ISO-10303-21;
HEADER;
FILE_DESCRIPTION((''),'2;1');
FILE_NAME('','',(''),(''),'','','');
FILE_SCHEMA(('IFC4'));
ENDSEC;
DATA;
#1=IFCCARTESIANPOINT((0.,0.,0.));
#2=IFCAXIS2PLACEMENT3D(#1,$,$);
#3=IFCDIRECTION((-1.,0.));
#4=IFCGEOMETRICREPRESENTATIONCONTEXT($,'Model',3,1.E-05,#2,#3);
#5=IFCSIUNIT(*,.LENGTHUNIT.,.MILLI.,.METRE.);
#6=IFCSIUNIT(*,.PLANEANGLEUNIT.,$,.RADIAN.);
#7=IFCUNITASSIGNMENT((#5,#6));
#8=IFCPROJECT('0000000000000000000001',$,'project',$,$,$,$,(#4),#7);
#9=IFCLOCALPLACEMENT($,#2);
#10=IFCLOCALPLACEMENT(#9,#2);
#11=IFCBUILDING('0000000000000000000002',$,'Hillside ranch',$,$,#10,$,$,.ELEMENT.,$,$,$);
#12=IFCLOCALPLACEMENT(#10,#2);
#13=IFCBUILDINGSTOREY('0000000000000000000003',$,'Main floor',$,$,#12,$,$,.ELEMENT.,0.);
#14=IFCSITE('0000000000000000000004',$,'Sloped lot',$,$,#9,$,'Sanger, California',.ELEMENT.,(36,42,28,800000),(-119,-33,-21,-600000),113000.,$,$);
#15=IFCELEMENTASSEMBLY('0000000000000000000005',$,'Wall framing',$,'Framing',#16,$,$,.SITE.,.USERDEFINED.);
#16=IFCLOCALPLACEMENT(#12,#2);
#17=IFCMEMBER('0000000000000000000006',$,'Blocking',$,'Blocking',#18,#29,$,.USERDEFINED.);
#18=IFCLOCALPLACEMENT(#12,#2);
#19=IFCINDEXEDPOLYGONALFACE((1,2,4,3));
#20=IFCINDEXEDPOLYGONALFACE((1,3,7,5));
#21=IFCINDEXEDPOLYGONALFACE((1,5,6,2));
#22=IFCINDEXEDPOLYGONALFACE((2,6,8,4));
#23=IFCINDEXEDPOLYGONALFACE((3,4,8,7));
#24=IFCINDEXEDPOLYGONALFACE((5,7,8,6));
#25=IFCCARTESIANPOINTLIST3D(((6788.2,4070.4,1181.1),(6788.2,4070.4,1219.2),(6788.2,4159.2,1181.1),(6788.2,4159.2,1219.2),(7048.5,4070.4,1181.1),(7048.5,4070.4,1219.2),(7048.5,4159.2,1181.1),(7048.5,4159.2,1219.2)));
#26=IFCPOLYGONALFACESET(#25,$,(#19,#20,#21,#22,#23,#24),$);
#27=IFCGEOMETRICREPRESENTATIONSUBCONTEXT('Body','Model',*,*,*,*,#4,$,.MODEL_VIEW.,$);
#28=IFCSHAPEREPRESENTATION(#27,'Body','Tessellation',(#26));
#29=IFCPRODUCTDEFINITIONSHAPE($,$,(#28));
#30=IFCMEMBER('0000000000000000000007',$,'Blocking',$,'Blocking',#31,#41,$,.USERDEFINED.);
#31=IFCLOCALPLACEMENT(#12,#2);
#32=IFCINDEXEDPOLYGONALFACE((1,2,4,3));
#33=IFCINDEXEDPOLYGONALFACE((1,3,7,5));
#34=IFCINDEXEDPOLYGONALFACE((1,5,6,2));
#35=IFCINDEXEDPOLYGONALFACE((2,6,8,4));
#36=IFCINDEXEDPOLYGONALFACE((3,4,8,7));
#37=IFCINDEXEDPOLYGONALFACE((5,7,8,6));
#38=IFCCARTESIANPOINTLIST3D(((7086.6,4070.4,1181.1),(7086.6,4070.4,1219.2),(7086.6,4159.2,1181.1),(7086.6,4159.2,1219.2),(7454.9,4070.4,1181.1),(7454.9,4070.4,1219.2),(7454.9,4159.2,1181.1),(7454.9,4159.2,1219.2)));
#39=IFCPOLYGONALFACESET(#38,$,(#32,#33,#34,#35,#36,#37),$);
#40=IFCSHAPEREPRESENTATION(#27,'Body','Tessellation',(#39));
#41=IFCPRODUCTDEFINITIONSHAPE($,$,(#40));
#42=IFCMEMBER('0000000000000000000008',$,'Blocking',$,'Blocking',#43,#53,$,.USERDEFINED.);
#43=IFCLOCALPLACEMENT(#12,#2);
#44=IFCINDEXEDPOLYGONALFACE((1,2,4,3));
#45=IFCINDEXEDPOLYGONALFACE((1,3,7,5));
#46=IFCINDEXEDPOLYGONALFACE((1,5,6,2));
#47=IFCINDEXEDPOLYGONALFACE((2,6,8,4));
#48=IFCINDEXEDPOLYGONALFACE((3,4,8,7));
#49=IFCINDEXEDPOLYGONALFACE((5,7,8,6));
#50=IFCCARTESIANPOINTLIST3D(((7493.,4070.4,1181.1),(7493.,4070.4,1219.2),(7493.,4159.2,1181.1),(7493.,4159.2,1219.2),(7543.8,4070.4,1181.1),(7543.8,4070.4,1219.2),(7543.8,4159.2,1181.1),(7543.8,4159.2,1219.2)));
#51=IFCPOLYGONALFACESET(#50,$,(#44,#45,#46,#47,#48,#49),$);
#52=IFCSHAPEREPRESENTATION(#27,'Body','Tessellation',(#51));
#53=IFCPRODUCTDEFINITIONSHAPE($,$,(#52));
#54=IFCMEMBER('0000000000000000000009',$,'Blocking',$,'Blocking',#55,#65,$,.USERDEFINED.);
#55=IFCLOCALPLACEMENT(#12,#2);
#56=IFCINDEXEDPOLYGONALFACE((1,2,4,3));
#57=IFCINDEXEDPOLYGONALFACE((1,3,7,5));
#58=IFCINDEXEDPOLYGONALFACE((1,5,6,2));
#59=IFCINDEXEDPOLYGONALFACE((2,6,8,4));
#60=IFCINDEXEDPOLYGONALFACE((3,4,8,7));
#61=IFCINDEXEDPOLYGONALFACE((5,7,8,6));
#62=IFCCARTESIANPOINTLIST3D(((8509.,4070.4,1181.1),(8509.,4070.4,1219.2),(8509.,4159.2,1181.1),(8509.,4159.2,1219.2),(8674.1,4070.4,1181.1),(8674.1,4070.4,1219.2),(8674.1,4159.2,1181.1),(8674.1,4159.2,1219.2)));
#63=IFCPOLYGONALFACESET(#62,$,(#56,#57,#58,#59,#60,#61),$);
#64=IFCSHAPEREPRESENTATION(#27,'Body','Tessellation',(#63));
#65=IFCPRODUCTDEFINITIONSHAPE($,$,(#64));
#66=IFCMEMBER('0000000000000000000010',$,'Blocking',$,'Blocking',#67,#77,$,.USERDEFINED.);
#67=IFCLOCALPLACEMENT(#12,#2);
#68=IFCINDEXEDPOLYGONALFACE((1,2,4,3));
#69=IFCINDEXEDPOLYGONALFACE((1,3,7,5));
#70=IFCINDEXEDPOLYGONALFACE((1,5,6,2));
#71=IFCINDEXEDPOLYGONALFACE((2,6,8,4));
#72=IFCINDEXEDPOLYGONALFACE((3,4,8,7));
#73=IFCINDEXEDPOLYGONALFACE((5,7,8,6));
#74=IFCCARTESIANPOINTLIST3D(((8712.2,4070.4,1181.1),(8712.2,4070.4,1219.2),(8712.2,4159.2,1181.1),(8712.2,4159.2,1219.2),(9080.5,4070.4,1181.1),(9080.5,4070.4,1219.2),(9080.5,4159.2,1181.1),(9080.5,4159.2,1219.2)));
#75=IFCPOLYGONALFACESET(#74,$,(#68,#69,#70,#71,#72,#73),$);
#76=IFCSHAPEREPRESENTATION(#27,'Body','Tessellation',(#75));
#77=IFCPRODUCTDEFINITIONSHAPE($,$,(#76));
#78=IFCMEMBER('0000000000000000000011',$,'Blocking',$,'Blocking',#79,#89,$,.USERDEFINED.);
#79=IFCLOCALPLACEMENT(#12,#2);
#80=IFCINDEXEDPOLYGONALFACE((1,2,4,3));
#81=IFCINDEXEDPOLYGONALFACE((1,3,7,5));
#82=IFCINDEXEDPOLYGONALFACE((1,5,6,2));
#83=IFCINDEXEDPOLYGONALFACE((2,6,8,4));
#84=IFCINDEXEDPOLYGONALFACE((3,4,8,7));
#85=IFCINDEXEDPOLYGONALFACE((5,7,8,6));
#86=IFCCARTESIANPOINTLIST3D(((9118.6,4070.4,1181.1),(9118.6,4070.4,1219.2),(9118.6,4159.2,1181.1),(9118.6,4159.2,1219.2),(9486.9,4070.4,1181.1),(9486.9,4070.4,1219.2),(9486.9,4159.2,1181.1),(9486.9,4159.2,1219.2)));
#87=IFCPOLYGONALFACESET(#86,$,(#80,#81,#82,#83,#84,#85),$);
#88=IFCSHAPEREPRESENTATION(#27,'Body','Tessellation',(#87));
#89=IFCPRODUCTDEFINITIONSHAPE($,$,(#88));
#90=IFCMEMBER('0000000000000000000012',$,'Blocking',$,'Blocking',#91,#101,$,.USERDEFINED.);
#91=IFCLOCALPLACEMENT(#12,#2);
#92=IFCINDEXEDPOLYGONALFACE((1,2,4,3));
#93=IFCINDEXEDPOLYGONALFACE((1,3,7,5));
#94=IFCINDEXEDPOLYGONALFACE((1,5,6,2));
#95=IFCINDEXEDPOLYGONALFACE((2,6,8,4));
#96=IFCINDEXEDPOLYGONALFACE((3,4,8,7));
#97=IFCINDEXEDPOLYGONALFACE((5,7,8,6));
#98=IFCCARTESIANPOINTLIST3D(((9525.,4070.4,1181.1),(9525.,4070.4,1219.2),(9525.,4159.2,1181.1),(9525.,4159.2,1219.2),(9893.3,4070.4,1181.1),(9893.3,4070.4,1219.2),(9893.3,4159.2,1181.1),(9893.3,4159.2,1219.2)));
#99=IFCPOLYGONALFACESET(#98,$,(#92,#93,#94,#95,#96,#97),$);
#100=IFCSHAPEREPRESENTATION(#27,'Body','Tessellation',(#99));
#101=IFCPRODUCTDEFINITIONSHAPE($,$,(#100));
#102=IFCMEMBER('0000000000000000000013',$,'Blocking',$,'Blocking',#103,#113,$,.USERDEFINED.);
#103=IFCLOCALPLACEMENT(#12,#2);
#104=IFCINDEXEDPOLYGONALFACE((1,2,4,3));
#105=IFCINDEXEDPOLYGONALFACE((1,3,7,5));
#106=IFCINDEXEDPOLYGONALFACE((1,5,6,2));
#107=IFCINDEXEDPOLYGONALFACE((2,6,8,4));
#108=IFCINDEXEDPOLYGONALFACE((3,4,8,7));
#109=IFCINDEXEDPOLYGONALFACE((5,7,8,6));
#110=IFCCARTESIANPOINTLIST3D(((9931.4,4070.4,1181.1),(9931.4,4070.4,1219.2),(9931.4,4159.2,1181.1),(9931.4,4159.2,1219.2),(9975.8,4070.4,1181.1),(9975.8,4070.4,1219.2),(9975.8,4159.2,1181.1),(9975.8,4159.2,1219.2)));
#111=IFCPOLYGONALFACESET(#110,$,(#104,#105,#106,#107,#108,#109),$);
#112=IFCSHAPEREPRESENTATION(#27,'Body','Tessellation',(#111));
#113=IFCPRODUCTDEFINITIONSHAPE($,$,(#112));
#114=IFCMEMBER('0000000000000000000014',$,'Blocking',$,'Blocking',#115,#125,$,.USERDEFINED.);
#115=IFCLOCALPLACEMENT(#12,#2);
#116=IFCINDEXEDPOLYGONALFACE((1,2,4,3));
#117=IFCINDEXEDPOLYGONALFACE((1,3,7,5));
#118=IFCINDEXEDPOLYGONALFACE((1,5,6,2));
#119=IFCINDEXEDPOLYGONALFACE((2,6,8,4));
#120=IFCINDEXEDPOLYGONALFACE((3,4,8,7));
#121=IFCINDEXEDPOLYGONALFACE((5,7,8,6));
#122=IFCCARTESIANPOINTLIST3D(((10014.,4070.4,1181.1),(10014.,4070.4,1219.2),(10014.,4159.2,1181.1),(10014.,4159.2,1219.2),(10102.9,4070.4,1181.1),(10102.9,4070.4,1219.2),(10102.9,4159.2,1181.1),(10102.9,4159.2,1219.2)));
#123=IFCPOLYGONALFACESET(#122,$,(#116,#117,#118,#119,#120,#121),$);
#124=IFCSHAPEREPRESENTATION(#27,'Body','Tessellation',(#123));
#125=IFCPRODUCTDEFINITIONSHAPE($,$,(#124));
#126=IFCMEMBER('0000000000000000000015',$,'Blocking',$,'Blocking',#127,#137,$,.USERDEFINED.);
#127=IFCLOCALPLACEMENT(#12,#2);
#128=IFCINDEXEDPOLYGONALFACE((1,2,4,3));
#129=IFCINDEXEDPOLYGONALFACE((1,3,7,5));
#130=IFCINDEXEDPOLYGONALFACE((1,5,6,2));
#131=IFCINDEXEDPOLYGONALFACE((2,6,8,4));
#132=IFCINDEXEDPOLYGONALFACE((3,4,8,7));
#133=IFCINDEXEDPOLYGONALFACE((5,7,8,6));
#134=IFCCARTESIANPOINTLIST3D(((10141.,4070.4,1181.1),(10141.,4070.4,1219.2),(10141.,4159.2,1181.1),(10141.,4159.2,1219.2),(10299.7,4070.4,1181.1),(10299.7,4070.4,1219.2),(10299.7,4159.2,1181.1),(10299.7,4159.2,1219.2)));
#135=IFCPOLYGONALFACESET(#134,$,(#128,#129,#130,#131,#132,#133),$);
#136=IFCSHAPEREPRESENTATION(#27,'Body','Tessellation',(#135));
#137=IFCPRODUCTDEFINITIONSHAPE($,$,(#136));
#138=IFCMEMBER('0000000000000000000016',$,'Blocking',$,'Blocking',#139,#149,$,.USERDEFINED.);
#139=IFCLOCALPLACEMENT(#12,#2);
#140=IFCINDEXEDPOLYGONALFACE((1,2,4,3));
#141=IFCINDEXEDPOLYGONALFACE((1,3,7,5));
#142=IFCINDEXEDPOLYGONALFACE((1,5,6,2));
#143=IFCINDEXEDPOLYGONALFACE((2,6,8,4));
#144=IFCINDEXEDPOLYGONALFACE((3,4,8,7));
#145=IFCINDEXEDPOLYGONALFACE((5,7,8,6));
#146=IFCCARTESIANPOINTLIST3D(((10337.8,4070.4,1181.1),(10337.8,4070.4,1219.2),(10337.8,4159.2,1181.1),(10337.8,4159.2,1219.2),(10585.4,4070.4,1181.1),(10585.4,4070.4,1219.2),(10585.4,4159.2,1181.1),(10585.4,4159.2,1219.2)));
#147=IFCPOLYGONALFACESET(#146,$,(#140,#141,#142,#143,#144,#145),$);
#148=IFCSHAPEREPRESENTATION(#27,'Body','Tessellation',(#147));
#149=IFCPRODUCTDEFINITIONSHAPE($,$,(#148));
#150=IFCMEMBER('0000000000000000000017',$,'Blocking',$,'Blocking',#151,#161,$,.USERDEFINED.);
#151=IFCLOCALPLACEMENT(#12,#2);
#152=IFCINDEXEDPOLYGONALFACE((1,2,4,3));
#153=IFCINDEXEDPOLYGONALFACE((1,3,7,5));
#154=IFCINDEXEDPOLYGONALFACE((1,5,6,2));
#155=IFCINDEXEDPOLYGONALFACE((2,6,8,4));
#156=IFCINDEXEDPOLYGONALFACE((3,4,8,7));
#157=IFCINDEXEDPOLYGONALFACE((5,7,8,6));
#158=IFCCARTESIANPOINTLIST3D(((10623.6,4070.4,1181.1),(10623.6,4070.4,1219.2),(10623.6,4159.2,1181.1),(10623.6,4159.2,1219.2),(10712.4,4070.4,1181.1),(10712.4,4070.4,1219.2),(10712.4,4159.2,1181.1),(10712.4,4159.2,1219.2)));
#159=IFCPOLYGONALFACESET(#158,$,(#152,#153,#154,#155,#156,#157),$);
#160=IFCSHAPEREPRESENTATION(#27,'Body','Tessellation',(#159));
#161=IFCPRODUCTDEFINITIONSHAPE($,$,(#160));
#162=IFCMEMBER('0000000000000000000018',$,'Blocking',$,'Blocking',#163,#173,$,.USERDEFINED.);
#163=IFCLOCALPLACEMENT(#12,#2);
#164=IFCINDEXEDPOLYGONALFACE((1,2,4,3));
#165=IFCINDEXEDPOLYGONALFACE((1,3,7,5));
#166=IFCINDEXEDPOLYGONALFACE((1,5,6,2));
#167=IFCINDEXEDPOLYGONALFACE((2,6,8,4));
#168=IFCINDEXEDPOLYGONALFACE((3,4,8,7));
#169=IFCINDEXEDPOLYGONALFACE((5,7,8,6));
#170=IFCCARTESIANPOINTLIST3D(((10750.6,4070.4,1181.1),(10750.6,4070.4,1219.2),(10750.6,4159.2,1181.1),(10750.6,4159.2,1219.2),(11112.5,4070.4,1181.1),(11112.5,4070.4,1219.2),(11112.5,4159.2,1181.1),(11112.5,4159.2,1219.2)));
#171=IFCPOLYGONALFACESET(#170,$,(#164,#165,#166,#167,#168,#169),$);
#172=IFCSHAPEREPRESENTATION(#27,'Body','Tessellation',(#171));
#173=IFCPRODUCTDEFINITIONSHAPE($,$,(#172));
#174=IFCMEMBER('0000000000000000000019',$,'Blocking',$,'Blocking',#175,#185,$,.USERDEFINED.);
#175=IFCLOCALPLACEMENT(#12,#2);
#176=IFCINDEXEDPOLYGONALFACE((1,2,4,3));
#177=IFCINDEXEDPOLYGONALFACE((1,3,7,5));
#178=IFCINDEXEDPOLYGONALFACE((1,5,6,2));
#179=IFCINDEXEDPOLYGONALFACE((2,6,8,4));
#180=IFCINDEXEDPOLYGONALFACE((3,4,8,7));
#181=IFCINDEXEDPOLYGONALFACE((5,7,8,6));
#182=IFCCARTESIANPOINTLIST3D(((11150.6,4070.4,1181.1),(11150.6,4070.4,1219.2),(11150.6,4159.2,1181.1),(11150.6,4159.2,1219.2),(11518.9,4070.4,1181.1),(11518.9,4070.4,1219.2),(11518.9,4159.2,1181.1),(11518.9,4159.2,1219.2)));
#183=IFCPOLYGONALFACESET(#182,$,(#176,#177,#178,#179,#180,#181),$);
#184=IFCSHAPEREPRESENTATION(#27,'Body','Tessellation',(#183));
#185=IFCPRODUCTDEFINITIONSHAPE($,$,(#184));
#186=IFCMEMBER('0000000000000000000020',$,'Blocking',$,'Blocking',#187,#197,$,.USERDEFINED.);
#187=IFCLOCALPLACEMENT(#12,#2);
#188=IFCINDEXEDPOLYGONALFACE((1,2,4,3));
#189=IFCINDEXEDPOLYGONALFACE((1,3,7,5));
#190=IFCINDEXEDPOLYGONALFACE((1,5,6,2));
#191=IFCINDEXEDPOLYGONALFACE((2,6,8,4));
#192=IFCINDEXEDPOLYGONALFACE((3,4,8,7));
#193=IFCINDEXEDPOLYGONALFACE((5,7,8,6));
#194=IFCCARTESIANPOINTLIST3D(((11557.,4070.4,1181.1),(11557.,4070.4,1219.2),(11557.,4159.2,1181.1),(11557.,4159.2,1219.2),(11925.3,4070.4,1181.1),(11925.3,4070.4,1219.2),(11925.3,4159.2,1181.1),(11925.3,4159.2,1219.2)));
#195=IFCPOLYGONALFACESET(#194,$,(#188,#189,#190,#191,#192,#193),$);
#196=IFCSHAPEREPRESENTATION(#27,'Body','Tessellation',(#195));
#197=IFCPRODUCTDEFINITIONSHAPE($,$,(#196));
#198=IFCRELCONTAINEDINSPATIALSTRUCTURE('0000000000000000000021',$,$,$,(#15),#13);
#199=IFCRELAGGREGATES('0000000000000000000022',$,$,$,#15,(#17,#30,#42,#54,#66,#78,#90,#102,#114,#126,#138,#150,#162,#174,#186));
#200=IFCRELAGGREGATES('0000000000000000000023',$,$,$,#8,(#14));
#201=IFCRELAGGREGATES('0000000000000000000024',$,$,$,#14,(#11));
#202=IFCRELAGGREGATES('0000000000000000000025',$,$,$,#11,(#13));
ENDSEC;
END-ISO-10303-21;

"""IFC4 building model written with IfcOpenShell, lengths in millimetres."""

from ifc_helpers import new_model, si_unit, direction, frame, origin, origin_with_axes, place, context, subcontext, project, spatial, polyline, outline, extrude, element, aggregate, save


model = new_model("IFC4")

# Units and contexts
model_context = context("Model", 3, precision=1e-05, world=origin(), true_north=direction((-1.0, 0.0)))
body_context = subcontext(model_context, "Body", "Model", "MODEL_VIEW")
ifc_project = project(units=[si_unit("LENGTHUNIT", "METRE", prefix="MILLI"), si_unit("PLANEANGLEUNIT", "RADIAN")], contexts=[model_context])

# Site, building, storey
site_placement = place(None, origin())
site = spatial("IfcSite", under=ifc_project, at=site_placement, Name="Sloped lot", LongName="Sanger, California", CompositionType="ELEMENT", RefLatitude=(36, 42, 28, 800000), RefLongitude=(-119, -33, -21, -600000), RefElevation=113000.0)
building_placement = place(site_placement, origin())
building = spatial("IfcBuilding", under=site, at=building_placement, Name="Hillside ranch", CompositionType="ELEMENT")
storey_placement = place(building_placement, origin())
storey = spatial("IfcBuildingStorey", under=building, at=storey_placement, Name="Main floor", CompositionType="ELEMENT", Elevation=0.0)

# Element assembly, members
assembly_1_placement = place(storey_placement, origin_with_axes())
assembly_1 = element("IfcElementAssembly", 1, at=assembly_1_placement, inside=storey, Name="Wall framing", ObjectType="Framing", AssemblyPlace="SITE", PredefinedType="USERDEFINED")
member_1_placement = place(storey_placement, origin_with_axes())
member_1 = element("IfcMember", 2, at=member_1_placement, Name="Blocking", ObjectType="Blocking", PredefinedType="USERDEFINED", context=body_context, shape_type="SweptSolid", body=[
    extrude(outline(polyline([(0.0, 0.0), (260.4, 0.0), (260.4, 88.9), (0.0, 88.9), (0.0, 0.0)])), frame((6788.1, 4070.3, 1181.1), z_axis=(0.0, 0.0, 1.0), x_axis=(1.0, 0.0, 0.0)), (0.0, 0.0, 1.0), 38.1),
])
member_2_placement = place(storey_placement, origin_with_axes())
member_2 = element("IfcMember", 3, at=member_2_placement, Name="Blocking", ObjectType="Blocking", PredefinedType="USERDEFINED", context=body_context, shape_type="SweptSolid", body=[
    extrude(outline(polyline([(0.0, 0.0), (368.3, 0.0), (368.3, 88.9), (0.0, 88.9), (0.0, 0.0)])), frame((7086.6, 4070.3, 1181.1), z_axis=(0.0, 0.0, 1.0), x_axis=(1.0, 0.0, 0.0)), (0.0, 0.0, 1.0), 38.1),
])
member_3_placement = place(storey_placement, origin_with_axes())
member_3 = element("IfcMember", 4, at=member_3_placement, Name="Blocking", ObjectType="Blocking", PredefinedType="USERDEFINED", context=body_context, shape_type="SweptSolid", body=[
    extrude(outline(polyline([(0.0, 0.0), (50.8, 0.0), (50.8, 88.9), (0.0, 88.9), (0.0, 0.0)])), frame((7493.0, 4070.3, 1181.1), z_axis=(0.0, 0.0, 1.0), x_axis=(1.0, 0.0, 0.0)), (0.0, 0.0, 1.0), 38.1),
])
member_4_placement = place(storey_placement, origin_with_axes())
member_4 = element("IfcMember", 5, at=member_4_placement, Name="Blocking", ObjectType="Blocking", PredefinedType="USERDEFINED", context=body_context, shape_type="SweptSolid", body=[
    extrude(outline(polyline([(0.0, 0.0), (165.1, 0.0), (165.1, 88.9), (0.0, 88.9), (0.0, 0.0)])), frame((8509.0, 4070.3, 1181.1), z_axis=(0.0, 0.0, 1.0), x_axis=(1.0, 0.0, 0.0)), (0.0, 0.0, 1.0), 38.1),
])
member_5_placement = place(storey_placement, origin_with_axes())
member_5 = element("IfcMember", 6, at=member_5_placement, Name="Blocking", ObjectType="Blocking", PredefinedType="USERDEFINED", context=body_context, shape_type="SweptSolid", body=[
    extrude(outline(polyline([(0.0, 0.0), (368.3, 0.0), (368.3, 88.9), (0.0, 88.9), (0.0, 0.0)])), frame((8712.2, 4070.3, 1181.1), z_axis=(0.0, 0.0, 1.0), x_axis=(1.0, 0.0, 0.0)), (0.0, 0.0, 1.0), 38.1),
])
member_6_placement = place(storey_placement, origin_with_axes())
member_6 = element("IfcMember", 7, at=member_6_placement, Name="Blocking", ObjectType="Blocking", PredefinedType="USERDEFINED", context=body_context, shape_type="SweptSolid", body=[
    extrude(outline(polyline([(0.0, 0.0), (368.3, 0.0), (368.3, 88.9), (0.0, 88.9), (0.0, 0.0)])), frame((9118.6, 4070.3, 1181.1), z_axis=(0.0, 0.0, 1.0), x_axis=(1.0, 0.0, 0.0)), (0.0, 0.0, 1.0), 38.1),
])
member_7_placement = place(storey_placement, origin_with_axes())
member_7 = element("IfcMember", 8, at=member_7_placement, Name="Blocking", ObjectType="Blocking", PredefinedType="USERDEFINED", context=body_context, shape_type="SweptSolid", body=[
    extrude(outline(polyline([(0.0, 0.0), (368.3, 0.0), (368.3, 88.9), (0.0, 88.9), (0.0, 0.0)])), frame((9525.0, 4070.3, 1181.1), z_axis=(0.0, 0.0, 1.0), x_axis=(1.0, 0.0, 0.0)), (0.0, 0.0, 1.0), 38.1),
])
member_8_placement = place(storey_placement, origin_with_axes())
member_8 = element("IfcMember", 9, at=member_8_placement, Name="Blocking", ObjectType="Blocking", PredefinedType="USERDEFINED", context=body_context, shape_type="SweptSolid", body=[
    extrude(outline(polyline([(0.0, 0.0), (44.5, 0.0), (44.5, 88.9), (0.0, 88.9), (0.0, 0.0)])), frame((9931.4, 4070.3, 1181.1), z_axis=(0.0, 0.0, 1.0), x_axis=(1.0, 0.0, 0.0)), (0.0, 0.0, 1.0), 38.1),
])
member_9_placement = place(storey_placement, origin_with_axes())
member_9 = element("IfcMember", 10, at=member_9_placement, Name="Blocking", ObjectType="Blocking", PredefinedType="USERDEFINED", context=body_context, shape_type="SweptSolid", body=[
    extrude(outline(polyline([(0.0, 0.0), (88.9, 0.0), (88.9, 88.9), (0.0, 88.9), (0.0, 0.0)])), frame((10014.0, 4070.3, 1181.1), z_axis=(0.0, 0.0, 1.0), x_axis=(1.0, 0.0, 0.0)), (0.0, 0.0, 1.0), 38.1),
])
member_10_placement = place(storey_placement, origin_with_axes())
member_10 = element("IfcMember", 11, at=member_10_placement, Name="Blocking", ObjectType="Blocking", PredefinedType="USERDEFINED", context=body_context, shape_type="SweptSolid", body=[
    extrude(outline(polyline([(0.0, 0.0), (158.8, 0.0), (158.8, 88.9), (0.0, 88.9), (0.0, 0.0)])), frame((10141.0, 4070.3, 1181.1), z_axis=(0.0, 0.0, 1.0), x_axis=(1.0, 0.0, 0.0)), (0.0, 0.0, 1.0), 38.1),
])
member_11_placement = place(storey_placement, origin_with_axes())
member_11 = element("IfcMember", 12, at=member_11_placement, Name="Blocking", ObjectType="Blocking", PredefinedType="USERDEFINED", context=body_context, shape_type="SweptSolid", body=[
    extrude(outline(polyline([(0.0, 0.0), (247.7, 0.0), (247.7, 88.9), (0.0, 88.9), (0.0, 0.0)])), frame((10337.8, 4070.3, 1181.1), z_axis=(0.0, 0.0, 1.0), x_axis=(1.0, 0.0, 0.0)), (0.0, 0.0, 1.0), 38.1),
])
member_12_placement = place(storey_placement, origin_with_axes())
member_12 = element("IfcMember", 13, at=member_12_placement, Name="Blocking", ObjectType="Blocking", PredefinedType="USERDEFINED", context=body_context, shape_type="SweptSolid", body=[
    extrude(outline(polyline([(0.0, 0.0), (88.9, 0.0), (88.9, 88.9), (0.0, 88.9), (0.0, 0.0)])), frame((10623.5, 4070.3, 1181.1), z_axis=(0.0, 0.0, 1.0), x_axis=(1.0, 0.0, 0.0)), (0.0, 0.0, 1.0), 38.1),
])
member_13_placement = place(storey_placement, origin_with_axes())
member_13 = element("IfcMember", 14, at=member_13_placement, Name="Blocking", ObjectType="Blocking", PredefinedType="USERDEFINED", context=body_context, shape_type="SweptSolid", body=[
    extrude(outline(polyline([(0.0, 0.0), (361.9, 0.0), (361.9, 88.9), (0.0, 88.9), (0.0, 0.0)])), frame((10750.5, 4070.3, 1181.1), z_axis=(0.0, 0.0, 1.0), x_axis=(1.0, 0.0, 0.0)), (0.0, 0.0, 1.0), 38.1),
])
member_14_placement = place(storey_placement, origin_with_axes())
member_14 = element("IfcMember", 15, at=member_14_placement, Name="Blocking", ObjectType="Blocking", PredefinedType="USERDEFINED", context=body_context, shape_type="SweptSolid", body=[
    extrude(outline(polyline([(0.0, 0.0), (368.3, 0.0), (368.3, 88.9), (0.0, 88.9), (0.0, 0.0)])), frame((11150.6, 4070.3, 1181.1), z_axis=(0.0, 0.0, 1.0), x_axis=(1.0, 0.0, 0.0)), (0.0, 0.0, 1.0), 38.1),
])
member_15_placement = place(storey_placement, origin_with_axes())
member_15 = element("IfcMember", 16, at=member_15_placement, Name="Blocking", ObjectType="Blocking", PredefinedType="USERDEFINED", context=body_context, shape_type="SweptSolid", body=[
    extrude(outline(polyline([(0.0, 0.0), (368.3, 0.0), (368.3, 88.9), (0.0, 88.9), (0.0, 0.0)])), frame((11557.0, 4070.3, 1181.1), z_axis=(0.0, 0.0, 1.0), x_axis=(1.0, 0.0, 0.0)), (0.0, 0.0, 1.0), 38.1),
])
aggregate(assembly_1, [member_1, member_2, member_3, member_4, member_5, member_6, member_7, member_8, member_9, member_10, member_11, member_12, member_13, member_14, member_15])

save(model, "model.ifc")
